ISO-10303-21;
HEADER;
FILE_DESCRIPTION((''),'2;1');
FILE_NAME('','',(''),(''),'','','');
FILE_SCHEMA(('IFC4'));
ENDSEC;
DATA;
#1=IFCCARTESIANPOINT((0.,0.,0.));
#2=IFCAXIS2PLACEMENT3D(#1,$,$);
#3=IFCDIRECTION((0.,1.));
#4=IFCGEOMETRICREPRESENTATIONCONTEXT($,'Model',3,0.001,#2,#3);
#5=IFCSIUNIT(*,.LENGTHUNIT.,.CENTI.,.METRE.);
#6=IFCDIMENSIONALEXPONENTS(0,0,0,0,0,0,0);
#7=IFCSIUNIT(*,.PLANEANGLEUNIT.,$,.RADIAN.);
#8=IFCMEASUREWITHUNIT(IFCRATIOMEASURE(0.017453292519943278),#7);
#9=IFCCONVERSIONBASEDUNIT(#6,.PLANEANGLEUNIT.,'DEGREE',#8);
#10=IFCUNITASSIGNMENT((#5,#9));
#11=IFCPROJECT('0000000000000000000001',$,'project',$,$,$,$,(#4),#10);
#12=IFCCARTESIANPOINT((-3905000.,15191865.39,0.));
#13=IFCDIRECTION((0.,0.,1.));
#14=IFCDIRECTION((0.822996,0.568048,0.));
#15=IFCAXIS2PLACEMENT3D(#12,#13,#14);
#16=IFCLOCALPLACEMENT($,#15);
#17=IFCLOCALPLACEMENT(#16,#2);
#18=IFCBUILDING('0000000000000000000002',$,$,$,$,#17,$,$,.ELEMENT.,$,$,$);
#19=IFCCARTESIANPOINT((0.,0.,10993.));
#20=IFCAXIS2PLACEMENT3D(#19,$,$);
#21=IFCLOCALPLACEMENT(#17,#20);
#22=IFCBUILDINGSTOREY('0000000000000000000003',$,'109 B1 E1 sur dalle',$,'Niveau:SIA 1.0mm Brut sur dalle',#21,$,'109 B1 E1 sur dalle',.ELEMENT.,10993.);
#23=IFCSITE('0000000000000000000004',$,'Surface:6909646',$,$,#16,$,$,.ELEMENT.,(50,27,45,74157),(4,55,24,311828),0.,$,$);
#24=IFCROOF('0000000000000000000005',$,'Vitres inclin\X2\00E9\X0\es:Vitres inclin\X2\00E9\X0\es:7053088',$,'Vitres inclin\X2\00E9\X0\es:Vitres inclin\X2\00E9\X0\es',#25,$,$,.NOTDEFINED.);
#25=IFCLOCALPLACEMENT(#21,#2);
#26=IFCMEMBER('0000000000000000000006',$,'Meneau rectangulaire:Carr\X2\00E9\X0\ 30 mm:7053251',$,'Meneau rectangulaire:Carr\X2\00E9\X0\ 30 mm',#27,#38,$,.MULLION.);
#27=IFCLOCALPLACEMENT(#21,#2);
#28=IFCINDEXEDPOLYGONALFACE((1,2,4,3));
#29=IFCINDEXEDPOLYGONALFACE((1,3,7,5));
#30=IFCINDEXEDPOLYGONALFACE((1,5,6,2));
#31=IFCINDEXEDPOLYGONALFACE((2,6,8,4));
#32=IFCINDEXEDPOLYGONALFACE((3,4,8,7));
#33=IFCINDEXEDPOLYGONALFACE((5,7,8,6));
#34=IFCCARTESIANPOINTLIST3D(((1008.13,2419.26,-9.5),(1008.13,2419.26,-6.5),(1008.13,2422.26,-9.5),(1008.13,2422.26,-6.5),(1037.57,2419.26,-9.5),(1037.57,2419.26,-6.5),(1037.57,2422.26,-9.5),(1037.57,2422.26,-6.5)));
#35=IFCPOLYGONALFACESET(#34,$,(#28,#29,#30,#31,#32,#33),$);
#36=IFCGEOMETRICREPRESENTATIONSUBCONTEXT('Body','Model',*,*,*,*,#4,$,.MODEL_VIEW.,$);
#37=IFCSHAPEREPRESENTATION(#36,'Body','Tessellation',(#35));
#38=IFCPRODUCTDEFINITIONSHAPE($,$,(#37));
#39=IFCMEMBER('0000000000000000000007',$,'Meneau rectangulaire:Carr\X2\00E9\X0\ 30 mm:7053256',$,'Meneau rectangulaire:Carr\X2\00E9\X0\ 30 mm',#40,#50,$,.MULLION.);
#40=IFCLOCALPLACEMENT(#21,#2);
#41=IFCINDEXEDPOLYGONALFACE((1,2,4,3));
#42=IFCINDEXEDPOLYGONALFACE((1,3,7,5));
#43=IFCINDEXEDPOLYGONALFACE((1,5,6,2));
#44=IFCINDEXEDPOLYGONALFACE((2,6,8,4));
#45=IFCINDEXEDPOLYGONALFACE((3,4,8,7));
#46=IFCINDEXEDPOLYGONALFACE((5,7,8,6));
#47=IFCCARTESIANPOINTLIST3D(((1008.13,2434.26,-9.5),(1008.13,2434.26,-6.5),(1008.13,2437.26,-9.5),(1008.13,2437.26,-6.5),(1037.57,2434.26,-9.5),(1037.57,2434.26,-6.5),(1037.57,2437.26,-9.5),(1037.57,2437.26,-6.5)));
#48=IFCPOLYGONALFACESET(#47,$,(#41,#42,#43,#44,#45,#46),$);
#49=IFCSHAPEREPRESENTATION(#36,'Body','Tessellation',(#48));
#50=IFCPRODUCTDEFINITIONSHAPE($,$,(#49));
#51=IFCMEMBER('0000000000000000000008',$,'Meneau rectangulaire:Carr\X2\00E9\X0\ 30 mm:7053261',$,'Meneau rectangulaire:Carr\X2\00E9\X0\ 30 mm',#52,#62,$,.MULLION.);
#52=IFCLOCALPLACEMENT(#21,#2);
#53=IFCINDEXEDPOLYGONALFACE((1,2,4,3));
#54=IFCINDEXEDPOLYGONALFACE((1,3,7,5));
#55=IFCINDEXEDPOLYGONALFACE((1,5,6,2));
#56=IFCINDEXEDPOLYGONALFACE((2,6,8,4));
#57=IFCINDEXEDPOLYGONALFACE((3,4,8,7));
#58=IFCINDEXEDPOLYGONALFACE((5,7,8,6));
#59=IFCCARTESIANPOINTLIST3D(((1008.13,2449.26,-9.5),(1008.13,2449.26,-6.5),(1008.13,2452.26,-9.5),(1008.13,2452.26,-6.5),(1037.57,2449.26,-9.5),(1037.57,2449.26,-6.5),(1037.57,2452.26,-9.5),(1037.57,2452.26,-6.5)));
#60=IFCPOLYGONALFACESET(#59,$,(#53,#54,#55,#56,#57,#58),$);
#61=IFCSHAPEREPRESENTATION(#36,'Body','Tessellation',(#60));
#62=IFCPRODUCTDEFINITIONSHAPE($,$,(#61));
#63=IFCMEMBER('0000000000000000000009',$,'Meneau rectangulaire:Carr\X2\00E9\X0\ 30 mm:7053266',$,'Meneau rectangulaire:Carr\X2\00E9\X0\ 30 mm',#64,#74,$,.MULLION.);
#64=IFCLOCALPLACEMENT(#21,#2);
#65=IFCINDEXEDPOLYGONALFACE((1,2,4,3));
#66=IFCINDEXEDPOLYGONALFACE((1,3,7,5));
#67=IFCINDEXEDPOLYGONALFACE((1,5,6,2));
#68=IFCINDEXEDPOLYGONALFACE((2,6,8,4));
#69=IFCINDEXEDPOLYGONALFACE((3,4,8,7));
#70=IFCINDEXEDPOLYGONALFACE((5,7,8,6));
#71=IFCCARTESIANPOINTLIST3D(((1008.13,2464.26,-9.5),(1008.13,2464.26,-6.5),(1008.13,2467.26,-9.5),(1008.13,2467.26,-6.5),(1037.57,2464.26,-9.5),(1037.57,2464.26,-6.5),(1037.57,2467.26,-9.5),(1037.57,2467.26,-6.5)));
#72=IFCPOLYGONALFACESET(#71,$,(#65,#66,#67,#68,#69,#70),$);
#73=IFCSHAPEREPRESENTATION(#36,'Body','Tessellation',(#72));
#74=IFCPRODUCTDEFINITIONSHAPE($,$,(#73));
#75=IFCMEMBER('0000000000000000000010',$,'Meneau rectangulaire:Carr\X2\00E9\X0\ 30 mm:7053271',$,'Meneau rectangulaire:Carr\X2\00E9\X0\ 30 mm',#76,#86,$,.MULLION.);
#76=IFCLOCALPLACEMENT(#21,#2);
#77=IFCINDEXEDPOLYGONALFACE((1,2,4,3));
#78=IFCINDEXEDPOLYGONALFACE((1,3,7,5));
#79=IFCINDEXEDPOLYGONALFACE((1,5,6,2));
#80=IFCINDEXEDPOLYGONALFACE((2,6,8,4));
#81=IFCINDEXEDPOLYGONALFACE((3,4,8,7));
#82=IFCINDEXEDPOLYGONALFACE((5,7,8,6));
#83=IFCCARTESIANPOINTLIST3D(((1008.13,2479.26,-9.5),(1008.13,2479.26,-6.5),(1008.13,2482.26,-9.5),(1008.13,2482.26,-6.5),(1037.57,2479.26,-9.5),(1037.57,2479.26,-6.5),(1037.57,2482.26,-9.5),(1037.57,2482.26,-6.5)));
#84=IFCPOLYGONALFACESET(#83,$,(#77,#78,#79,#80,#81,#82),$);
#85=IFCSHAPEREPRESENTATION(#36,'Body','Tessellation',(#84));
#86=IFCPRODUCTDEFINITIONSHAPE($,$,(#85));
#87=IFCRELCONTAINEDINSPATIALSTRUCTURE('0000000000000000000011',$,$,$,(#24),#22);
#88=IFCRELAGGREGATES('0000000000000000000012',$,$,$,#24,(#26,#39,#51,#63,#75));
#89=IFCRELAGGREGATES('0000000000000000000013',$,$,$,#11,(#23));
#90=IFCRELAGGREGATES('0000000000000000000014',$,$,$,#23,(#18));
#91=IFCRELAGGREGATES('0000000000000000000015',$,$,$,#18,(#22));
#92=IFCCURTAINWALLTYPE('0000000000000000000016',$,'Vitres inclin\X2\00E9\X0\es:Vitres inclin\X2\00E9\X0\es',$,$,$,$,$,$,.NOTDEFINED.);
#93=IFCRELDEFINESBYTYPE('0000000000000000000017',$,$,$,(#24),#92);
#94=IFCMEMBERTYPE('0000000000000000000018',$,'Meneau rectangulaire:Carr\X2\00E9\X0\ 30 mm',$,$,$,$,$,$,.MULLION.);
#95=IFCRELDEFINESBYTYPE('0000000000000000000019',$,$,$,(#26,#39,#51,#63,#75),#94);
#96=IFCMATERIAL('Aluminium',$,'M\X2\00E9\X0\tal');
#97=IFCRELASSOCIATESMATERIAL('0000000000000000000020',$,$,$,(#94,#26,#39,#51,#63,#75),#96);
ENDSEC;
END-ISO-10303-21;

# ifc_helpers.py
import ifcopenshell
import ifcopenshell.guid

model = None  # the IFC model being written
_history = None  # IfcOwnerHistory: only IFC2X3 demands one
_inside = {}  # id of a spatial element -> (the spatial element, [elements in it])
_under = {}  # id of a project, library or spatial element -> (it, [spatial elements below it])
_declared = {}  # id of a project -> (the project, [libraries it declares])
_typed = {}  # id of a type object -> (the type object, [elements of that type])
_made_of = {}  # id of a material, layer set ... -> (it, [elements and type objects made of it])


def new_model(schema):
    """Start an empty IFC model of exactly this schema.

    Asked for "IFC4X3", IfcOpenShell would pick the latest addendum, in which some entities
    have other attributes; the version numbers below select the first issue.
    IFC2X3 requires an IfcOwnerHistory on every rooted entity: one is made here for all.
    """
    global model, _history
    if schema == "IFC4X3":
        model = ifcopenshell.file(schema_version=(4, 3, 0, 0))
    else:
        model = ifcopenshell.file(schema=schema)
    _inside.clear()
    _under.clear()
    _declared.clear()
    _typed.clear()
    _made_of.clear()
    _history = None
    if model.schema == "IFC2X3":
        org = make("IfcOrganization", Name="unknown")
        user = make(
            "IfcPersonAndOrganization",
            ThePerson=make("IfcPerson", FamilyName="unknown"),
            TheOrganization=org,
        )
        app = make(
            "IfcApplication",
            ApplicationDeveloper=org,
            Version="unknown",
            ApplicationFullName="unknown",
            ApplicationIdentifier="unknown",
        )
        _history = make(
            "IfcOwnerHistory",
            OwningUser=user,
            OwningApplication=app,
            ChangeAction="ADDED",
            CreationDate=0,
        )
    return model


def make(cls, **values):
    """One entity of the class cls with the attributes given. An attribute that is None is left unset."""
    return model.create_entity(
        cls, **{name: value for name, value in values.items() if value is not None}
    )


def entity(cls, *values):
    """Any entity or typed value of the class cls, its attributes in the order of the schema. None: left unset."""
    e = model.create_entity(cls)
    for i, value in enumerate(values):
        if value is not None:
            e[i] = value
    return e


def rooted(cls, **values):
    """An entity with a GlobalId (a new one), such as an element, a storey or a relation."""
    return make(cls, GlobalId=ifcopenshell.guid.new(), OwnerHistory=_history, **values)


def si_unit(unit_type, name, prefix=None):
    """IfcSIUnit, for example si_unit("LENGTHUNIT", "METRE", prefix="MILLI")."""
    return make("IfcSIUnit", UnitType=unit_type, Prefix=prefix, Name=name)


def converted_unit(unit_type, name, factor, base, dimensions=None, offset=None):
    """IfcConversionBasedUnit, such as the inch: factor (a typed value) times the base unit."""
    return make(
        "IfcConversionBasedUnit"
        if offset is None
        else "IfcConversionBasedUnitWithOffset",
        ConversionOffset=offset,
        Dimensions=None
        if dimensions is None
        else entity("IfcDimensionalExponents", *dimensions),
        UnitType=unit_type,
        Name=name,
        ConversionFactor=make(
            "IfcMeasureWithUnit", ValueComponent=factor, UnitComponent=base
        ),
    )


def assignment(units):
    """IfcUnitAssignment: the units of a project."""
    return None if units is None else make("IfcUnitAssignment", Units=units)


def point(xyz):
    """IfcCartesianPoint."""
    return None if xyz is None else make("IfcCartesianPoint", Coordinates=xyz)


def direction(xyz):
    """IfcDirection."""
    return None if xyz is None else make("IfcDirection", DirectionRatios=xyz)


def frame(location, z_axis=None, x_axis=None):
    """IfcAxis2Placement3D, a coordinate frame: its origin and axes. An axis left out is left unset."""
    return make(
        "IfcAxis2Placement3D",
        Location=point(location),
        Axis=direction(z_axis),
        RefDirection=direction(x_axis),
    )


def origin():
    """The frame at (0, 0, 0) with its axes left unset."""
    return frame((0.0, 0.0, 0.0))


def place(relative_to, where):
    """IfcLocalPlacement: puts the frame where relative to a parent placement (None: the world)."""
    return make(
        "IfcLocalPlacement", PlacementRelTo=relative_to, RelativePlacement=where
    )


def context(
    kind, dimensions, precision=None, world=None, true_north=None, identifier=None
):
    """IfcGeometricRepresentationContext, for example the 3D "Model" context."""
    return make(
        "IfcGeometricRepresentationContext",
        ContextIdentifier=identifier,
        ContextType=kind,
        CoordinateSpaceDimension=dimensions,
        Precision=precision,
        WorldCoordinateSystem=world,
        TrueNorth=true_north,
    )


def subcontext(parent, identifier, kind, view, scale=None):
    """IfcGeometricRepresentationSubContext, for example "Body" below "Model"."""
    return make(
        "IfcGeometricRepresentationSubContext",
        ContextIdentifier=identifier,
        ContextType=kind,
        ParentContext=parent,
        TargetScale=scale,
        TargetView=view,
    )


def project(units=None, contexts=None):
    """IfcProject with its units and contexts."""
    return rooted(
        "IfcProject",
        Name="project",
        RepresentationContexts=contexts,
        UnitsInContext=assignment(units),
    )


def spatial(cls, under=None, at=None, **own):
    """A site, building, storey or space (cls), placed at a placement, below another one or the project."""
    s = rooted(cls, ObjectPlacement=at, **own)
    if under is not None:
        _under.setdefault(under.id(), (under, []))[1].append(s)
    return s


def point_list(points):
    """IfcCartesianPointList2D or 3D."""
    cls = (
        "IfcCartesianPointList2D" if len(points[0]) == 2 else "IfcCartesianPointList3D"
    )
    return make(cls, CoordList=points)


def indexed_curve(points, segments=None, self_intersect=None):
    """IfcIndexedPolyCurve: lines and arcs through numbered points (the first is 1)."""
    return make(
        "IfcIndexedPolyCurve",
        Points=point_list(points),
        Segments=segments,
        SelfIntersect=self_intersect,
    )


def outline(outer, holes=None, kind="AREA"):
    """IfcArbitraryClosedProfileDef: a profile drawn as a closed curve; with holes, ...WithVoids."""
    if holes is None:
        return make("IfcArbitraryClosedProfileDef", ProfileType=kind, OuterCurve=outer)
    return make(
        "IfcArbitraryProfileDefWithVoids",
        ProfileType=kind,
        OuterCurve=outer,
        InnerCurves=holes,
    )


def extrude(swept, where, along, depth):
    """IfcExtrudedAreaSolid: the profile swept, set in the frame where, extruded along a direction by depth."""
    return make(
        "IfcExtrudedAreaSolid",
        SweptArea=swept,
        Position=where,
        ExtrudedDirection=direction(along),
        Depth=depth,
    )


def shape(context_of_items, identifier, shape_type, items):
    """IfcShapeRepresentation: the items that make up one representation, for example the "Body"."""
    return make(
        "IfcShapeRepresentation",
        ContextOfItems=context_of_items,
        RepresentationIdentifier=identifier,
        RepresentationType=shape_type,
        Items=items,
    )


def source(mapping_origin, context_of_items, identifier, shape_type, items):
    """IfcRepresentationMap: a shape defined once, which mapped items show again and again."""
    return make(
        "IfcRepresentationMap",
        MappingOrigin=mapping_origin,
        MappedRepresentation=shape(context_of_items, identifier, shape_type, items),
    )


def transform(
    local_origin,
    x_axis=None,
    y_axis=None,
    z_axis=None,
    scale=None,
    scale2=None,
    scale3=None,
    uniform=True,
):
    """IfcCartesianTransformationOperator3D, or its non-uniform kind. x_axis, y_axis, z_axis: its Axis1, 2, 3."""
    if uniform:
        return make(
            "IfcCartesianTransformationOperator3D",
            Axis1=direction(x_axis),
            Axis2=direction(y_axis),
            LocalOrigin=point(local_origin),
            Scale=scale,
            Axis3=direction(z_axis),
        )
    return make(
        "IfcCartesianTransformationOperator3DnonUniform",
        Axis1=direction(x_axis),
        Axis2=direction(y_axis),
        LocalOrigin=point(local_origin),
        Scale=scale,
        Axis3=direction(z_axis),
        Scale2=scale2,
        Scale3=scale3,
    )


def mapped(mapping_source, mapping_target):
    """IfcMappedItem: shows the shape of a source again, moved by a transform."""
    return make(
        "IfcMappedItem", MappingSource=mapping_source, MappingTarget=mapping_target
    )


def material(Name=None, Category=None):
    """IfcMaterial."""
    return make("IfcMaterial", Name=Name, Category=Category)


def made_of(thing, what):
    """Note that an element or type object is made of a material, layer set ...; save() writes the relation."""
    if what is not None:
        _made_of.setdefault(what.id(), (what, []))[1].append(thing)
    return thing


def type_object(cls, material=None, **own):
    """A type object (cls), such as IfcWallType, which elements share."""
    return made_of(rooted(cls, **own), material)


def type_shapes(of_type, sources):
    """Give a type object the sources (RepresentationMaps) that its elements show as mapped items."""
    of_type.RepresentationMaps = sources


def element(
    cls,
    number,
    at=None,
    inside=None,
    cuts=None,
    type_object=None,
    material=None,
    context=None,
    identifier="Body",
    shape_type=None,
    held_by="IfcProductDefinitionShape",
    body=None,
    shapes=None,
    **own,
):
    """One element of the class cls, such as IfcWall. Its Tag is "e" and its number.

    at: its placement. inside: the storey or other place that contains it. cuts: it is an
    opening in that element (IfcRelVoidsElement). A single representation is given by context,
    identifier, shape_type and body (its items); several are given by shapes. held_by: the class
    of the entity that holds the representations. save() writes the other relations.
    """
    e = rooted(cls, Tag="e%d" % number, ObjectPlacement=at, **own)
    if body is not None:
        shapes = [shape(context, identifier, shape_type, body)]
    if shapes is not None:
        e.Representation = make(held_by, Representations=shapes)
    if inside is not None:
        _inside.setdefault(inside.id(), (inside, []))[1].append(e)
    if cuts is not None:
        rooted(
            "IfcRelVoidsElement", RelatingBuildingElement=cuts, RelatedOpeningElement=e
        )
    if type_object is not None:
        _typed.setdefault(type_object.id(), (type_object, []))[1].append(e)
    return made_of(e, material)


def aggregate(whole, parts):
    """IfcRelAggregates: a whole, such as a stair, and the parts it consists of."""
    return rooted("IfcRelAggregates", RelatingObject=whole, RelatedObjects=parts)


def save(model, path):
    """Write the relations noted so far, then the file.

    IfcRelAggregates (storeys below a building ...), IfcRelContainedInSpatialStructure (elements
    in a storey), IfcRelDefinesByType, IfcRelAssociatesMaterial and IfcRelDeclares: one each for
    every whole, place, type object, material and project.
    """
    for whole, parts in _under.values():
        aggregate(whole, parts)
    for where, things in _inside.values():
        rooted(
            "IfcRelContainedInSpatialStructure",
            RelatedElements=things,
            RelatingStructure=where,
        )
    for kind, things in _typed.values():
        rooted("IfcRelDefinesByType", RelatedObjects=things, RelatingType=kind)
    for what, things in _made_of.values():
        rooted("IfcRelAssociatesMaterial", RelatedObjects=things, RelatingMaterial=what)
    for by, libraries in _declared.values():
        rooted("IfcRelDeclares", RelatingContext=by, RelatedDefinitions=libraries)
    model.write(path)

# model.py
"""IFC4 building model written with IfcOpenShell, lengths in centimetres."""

from ifc_helpers import new_model, entity, si_unit, converted_unit, direction, frame, origin, place, context, subcontext, project, spatial, indexed_curve, outline, extrude, source, transform, mapped, material, type_object, type_shapes, element, aggregate, save


model = new_model("IFC4")

# Units and contexts
model_context = context("Model", 3, precision=0.001, world=origin(), true_north=direction((0.0, 1.0)))
body_context = subcontext(model_context, "Body", "Model", "MODEL_VIEW")
ifc_project = project(units=[si_unit("LENGTHUNIT", "METRE", prefix="CENTI"), converted_unit("PLANEANGLEUNIT", "DEGREE", entity("IfcRatioMeasure", 0.017453292519943278), si_unit("PLANEANGLEUNIT", "RADIAN"), dimensions=[0, 0, 0, 0, 0, 0, 0])], contexts=[model_context])

# Site, building, storey
site_placement = place(None, frame((-3905000.0, 15191865.39, 0.0), z_axis=(0.0, 0.0, 1.0), x_axis=(0.822996, 0.568048, 0.0)))
site = spatial("IfcSite", under=ifc_project, at=site_placement, Name="Surface:6909646", CompositionType="ELEMENT", RefLatitude=(50, 27, 45, 74157), RefLongitude=(4, 55, 24, 311828), RefElevation=0.0)
building_placement = place(site_placement, origin())
building = spatial("IfcBuilding", under=site, at=building_placement, CompositionType="ELEMENT")
storey_placement = place(building_placement, frame((0.0, 0.0, 10993.0)))
storey = spatial("IfcBuildingStorey", under=building, at=storey_placement, Name="109 B1 E1 sur dalle", ObjectType="Niveau:SIA 1.0mm Brut sur dalle", LongName="109 B1 E1 sur dalle", CompositionType="ELEMENT", Elevation=10993.0)

# Roof, members
curtain_wall_type = type_object("IfcCurtainWallType", Name="Vitres inclinées:Vitres inclinées", PredefinedType="NOTDEFINED")
roof_placement = place(storey_placement, frame((0.0, 0.0, -10993.0)))
roof = element("IfcRoof", 1, at=roof_placement, inside=storey, type_object=curtain_wall_type, Name="Vitres inclinées:Vitres inclinées:7053088", ObjectType="Vitres inclinées:Vitres inclinées", PredefinedType="NOTDEFINED")
ifc_material = material(Name="Aluminium", Category="Métal")
member_type_1 = type_object("IfcMemberType", Name="Meneau rectangulaire:Carré 30 mm", PredefinedType="MULLION", material=ifc_material)
shared_shape_1 = source(origin(), body_context, "Body", "SweptSolid", [
    extrude(outline(indexed_curve([(-1.5, -1.5), (1.5, -1.5), (1.5, 1.5), (-1.5, 1.5), (-1.5, -1.5)], self_intersect=False)), frame((0.0, 0.0, -29.44), z_axis=(0.0, 0.0, 1.0), x_axis=(0.0, -1.0, 0.0)), (0.0, 0.0, 1.0), 29.44),
])
type_shapes(member_type_1, [shared_shape_1])
member_1_placement = place(roof_placement, frame((1008.13, 2420.76, 10985.0), z_axis=(-1.0, 0.0, 0.0), x_axis=(0.0, 1.0, 0.0)))
member_1 = element("IfcMember", 2, at=member_1_placement, type_object=member_type_1, material=ifc_material, Name="Meneau rectangulaire:Carré 30 mm:7053251", ObjectType="Meneau rectangulaire:Carré 30 mm", PredefinedType="MULLION", context=body_context, shape_type="MappedRepresentation", body=[
    mapped(shared_shape_1, transform((0.0, 0.0, 0.0), scale=1.0)),
])
member_2_placement = place(roof_placement, frame((1008.13, 2435.76, 10985.0), z_axis=(-1.0, 0.0, 0.0), x_axis=(0.0, 1.0, 0.0)))
member_2 = element("IfcMember", 3, at=member_2_placement, type_object=member_type_1, material=ifc_material, Name="Meneau rectangulaire:Carré 30 mm:7053256", ObjectType="Meneau rectangulaire:Carré 30 mm", PredefinedType="MULLION", context=body_context, shape_type="MappedRepresentation", body=[
    mapped(shared_shape_1, transform((0.0, 0.0, 0.0), scale=1.0)),
])
member_3_placement = place(roof_placement, frame((1008.13, 2450.76, 10985.0), z_axis=(-1.0, 0.0, 0.0), x_axis=(0.0, 1.0, 0.0)))
member_3 = element("IfcMember", 4, at=member_3_placement, type_object=member_type_1, material=ifc_material, Name="Meneau rectangulaire:Carré 30 mm:7053261", ObjectType="Meneau rectangulaire:Carré 30 mm", PredefinedType="MULLION", context=body_context, shape_type="MappedRepresentation", body=[
    mapped(shared_shape_1, transform((0.0, 0.0, 0.0), scale=1.0)),
])
member_4_placement = place(roof_placement, frame((1008.13, 2465.76, 10985.0), z_axis=(-1.0, 0.0, 0.0), x_axis=(0.0, 1.0, 0.0)))
member_4 = element("IfcMember", 5, at=member_4_placement, type_object=member_type_1, material=ifc_material, Name="Meneau rectangulaire:Carré 30 mm:7053266", ObjectType="Meneau rectangulaire:Carré 30 mm", PredefinedType="MULLION", context=body_context, shape_type="MappedRepresentation", body=[
    mapped(shared_shape_1, transform((0.0, 0.0, 0.0), scale=1.0)),
])
member_5_placement = place(roof_placement, frame((1008.13, 2480.76, 10985.0), z_axis=(-1.0, 0.0, 0.0), x_axis=(0.0, 1.0, 0.0)))
member_5 = element("IfcMember", 6, at=member_5_placement, type_object=member_type_1, material=ifc_material, Name="Meneau rectangulaire:Carré 30 mm:7053271", ObjectType="Meneau rectangulaire:Carré 30 mm", PredefinedType="MULLION", context=body_context, shape_type="MappedRepresentation", body=[
    mapped(shared_shape_1, transform((0.0, 0.0, 0.0), scale=1.0)),
])
aggregate(roof, [member_1, member_2, member_3, member_4, member_5])

save(model, "model.ifc")
